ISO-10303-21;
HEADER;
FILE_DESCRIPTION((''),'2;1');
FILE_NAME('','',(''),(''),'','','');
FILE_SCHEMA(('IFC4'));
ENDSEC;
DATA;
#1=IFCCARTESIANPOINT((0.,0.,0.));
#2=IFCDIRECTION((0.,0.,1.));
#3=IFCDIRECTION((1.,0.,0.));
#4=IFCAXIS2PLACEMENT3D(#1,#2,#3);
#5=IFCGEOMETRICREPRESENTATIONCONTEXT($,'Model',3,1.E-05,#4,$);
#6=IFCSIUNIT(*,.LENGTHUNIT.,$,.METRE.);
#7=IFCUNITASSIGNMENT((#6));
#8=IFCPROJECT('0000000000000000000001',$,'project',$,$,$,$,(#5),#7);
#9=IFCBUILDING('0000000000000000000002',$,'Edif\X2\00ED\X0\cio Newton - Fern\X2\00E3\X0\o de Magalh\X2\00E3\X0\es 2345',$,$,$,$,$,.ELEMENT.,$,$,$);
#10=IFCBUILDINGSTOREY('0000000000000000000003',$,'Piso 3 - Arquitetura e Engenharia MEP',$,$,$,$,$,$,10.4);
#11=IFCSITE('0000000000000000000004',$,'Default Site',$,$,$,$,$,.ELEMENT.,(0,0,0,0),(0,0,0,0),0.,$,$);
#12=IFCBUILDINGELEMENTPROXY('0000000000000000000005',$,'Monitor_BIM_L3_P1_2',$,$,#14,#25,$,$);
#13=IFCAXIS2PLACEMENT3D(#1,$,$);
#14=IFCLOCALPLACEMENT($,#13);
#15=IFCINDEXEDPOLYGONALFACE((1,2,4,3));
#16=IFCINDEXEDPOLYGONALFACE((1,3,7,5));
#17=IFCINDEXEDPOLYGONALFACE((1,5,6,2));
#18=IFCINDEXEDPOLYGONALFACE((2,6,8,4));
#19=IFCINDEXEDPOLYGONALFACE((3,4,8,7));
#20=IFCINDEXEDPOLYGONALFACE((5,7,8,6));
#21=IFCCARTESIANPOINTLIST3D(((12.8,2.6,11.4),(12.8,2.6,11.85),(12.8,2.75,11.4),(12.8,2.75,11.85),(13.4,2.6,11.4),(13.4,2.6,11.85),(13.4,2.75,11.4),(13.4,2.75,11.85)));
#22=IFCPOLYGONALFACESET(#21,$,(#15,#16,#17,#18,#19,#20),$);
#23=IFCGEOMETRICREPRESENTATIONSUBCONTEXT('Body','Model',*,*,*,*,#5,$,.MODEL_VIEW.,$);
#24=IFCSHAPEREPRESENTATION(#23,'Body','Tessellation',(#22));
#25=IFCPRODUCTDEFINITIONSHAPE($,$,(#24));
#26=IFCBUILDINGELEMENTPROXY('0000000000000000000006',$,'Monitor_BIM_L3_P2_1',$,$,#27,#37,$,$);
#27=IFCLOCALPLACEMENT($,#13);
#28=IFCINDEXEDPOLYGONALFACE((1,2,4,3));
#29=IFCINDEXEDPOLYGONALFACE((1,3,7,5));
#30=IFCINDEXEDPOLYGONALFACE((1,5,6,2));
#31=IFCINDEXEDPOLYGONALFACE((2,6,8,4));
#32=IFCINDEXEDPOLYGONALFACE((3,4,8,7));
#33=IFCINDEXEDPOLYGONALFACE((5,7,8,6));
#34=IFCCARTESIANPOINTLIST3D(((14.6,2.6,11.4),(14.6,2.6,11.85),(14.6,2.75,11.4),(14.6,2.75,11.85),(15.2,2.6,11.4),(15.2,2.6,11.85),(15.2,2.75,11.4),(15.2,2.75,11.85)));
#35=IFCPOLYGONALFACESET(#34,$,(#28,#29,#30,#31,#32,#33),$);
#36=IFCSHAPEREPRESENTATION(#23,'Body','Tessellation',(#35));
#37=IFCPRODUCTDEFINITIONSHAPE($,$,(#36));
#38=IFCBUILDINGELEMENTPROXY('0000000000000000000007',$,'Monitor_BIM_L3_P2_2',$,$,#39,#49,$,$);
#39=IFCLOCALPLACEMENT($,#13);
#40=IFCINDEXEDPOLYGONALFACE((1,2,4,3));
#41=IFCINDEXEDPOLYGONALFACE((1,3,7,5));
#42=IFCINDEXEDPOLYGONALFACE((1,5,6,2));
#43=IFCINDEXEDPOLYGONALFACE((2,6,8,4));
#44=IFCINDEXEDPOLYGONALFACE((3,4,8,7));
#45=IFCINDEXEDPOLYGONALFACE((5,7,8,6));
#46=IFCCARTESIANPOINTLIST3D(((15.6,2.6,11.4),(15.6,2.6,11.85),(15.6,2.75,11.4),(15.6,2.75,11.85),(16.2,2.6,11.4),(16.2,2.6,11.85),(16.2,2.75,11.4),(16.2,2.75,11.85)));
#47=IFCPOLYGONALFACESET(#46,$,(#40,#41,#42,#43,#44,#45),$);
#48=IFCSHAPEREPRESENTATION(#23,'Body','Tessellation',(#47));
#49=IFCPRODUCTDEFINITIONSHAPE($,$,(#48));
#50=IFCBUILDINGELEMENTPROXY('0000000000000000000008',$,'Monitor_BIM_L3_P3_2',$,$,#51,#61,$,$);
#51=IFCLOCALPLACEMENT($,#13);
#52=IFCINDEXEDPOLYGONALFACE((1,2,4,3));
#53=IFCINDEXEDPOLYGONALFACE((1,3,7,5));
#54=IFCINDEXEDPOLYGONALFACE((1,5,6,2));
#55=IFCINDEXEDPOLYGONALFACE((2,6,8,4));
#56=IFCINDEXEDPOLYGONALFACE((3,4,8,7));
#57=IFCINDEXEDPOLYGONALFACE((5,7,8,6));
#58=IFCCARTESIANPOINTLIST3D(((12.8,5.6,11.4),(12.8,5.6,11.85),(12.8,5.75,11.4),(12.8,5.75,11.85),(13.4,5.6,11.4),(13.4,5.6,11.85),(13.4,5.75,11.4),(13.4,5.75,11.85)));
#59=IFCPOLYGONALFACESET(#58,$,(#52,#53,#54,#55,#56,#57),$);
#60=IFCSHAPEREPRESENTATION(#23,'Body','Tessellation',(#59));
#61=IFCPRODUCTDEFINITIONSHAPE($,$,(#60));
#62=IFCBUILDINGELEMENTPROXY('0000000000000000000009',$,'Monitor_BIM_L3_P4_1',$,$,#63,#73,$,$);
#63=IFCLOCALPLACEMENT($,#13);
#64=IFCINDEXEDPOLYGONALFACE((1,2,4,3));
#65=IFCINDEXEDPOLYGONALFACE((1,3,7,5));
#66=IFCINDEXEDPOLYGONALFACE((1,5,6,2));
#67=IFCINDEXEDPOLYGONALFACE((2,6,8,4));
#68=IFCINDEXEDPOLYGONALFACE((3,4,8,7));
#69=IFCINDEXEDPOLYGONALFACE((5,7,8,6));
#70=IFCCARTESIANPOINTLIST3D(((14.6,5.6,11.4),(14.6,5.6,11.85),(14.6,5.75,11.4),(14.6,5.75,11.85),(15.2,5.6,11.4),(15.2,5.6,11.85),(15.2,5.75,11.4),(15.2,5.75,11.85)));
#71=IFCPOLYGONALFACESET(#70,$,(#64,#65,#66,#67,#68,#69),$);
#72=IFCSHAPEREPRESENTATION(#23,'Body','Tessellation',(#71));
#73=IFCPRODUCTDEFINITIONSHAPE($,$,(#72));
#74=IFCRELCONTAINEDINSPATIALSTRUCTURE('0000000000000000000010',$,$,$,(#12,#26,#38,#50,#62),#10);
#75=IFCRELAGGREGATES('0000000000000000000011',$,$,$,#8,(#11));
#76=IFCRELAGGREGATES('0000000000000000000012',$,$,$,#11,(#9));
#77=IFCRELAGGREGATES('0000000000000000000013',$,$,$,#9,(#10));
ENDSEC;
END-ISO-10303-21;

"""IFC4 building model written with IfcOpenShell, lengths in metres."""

from ifc_helpers import new_model, si_unit, frame, frame_2d, origin_with_axes, place, context, subcontext, project, spatial, rectangle, extrude, element, save


model = new_model("IFC4")

# Units and contexts
model_context = context("Model", 3, precision=1e-05, world=origin_with_axes())
body_context = subcontext(model_context, "Body", "Model", "MODEL_VIEW")
ifc_project = project(units=[si_unit("LENGTHUNIT", "METRE")], contexts=[model_context])

# Site, building, storey
site = spatial("IfcSite", under=ifc_project, Name="Default Site", CompositionType="ELEMENT", RefLatitude=(0, 0, 0, 0), RefLongitude=(0, 0, 0, 0), RefElevation=0.0)
building = spatial("IfcBuilding", under=site, Name="Edifício Newton - Fernão de Magalhães 2345", CompositionType="ELEMENT")
storey = spatial("IfcBuildingStorey", under=building, Name="Piso 3 - Arquitetura e Engenharia MEP", Elevation=10.4)

# Building element proxies
for number, where, z_axis, x_axis, name in (
    (1, (12.8, 2.6, 11.4), (0.0, 0.0, 1.0), (1.0, 0.0, 0.0), "Monitor_BIM_L3_P1_2"),
    (2, (14.6, 2.6, 11.4), (0.0, 0.0, 1.0), (1.0, 0.0, 0.0), "Monitor_BIM_L3_P2_1"),
    (3, (15.6, 2.6, 11.4), (0.0, 0.0, 1.0), (1.0, 0.0, 0.0), "Monitor_BIM_L3_P2_2"),
    (4, (12.8, 5.6, 11.4), (0.0, 0.0, 1.0), (1.0, 0.0, 0.0), "Monitor_BIM_L3_P3_2"),
    (5, (14.6, 5.6, 11.4), (0.0, 0.0, 1.0), (1.0, 0.0, 0.0), "Monitor_BIM_L3_P4_1"),
):
    element("IfcBuildingElementProxy", number, at=place(None, frame(where, z_axis=z_axis, x_axis=x_axis)), inside=storey, Name=name, context=body_context, shape_type="SweptSolid", body=[
        extrude(rectangle(XDim=0.6, YDim=0.15, at=frame_2d((0.3, 0.075))), origin_with_axes(), (0.0, 0.0, 1.0), 0.45),
    ])

save(model, "model.ifc")
